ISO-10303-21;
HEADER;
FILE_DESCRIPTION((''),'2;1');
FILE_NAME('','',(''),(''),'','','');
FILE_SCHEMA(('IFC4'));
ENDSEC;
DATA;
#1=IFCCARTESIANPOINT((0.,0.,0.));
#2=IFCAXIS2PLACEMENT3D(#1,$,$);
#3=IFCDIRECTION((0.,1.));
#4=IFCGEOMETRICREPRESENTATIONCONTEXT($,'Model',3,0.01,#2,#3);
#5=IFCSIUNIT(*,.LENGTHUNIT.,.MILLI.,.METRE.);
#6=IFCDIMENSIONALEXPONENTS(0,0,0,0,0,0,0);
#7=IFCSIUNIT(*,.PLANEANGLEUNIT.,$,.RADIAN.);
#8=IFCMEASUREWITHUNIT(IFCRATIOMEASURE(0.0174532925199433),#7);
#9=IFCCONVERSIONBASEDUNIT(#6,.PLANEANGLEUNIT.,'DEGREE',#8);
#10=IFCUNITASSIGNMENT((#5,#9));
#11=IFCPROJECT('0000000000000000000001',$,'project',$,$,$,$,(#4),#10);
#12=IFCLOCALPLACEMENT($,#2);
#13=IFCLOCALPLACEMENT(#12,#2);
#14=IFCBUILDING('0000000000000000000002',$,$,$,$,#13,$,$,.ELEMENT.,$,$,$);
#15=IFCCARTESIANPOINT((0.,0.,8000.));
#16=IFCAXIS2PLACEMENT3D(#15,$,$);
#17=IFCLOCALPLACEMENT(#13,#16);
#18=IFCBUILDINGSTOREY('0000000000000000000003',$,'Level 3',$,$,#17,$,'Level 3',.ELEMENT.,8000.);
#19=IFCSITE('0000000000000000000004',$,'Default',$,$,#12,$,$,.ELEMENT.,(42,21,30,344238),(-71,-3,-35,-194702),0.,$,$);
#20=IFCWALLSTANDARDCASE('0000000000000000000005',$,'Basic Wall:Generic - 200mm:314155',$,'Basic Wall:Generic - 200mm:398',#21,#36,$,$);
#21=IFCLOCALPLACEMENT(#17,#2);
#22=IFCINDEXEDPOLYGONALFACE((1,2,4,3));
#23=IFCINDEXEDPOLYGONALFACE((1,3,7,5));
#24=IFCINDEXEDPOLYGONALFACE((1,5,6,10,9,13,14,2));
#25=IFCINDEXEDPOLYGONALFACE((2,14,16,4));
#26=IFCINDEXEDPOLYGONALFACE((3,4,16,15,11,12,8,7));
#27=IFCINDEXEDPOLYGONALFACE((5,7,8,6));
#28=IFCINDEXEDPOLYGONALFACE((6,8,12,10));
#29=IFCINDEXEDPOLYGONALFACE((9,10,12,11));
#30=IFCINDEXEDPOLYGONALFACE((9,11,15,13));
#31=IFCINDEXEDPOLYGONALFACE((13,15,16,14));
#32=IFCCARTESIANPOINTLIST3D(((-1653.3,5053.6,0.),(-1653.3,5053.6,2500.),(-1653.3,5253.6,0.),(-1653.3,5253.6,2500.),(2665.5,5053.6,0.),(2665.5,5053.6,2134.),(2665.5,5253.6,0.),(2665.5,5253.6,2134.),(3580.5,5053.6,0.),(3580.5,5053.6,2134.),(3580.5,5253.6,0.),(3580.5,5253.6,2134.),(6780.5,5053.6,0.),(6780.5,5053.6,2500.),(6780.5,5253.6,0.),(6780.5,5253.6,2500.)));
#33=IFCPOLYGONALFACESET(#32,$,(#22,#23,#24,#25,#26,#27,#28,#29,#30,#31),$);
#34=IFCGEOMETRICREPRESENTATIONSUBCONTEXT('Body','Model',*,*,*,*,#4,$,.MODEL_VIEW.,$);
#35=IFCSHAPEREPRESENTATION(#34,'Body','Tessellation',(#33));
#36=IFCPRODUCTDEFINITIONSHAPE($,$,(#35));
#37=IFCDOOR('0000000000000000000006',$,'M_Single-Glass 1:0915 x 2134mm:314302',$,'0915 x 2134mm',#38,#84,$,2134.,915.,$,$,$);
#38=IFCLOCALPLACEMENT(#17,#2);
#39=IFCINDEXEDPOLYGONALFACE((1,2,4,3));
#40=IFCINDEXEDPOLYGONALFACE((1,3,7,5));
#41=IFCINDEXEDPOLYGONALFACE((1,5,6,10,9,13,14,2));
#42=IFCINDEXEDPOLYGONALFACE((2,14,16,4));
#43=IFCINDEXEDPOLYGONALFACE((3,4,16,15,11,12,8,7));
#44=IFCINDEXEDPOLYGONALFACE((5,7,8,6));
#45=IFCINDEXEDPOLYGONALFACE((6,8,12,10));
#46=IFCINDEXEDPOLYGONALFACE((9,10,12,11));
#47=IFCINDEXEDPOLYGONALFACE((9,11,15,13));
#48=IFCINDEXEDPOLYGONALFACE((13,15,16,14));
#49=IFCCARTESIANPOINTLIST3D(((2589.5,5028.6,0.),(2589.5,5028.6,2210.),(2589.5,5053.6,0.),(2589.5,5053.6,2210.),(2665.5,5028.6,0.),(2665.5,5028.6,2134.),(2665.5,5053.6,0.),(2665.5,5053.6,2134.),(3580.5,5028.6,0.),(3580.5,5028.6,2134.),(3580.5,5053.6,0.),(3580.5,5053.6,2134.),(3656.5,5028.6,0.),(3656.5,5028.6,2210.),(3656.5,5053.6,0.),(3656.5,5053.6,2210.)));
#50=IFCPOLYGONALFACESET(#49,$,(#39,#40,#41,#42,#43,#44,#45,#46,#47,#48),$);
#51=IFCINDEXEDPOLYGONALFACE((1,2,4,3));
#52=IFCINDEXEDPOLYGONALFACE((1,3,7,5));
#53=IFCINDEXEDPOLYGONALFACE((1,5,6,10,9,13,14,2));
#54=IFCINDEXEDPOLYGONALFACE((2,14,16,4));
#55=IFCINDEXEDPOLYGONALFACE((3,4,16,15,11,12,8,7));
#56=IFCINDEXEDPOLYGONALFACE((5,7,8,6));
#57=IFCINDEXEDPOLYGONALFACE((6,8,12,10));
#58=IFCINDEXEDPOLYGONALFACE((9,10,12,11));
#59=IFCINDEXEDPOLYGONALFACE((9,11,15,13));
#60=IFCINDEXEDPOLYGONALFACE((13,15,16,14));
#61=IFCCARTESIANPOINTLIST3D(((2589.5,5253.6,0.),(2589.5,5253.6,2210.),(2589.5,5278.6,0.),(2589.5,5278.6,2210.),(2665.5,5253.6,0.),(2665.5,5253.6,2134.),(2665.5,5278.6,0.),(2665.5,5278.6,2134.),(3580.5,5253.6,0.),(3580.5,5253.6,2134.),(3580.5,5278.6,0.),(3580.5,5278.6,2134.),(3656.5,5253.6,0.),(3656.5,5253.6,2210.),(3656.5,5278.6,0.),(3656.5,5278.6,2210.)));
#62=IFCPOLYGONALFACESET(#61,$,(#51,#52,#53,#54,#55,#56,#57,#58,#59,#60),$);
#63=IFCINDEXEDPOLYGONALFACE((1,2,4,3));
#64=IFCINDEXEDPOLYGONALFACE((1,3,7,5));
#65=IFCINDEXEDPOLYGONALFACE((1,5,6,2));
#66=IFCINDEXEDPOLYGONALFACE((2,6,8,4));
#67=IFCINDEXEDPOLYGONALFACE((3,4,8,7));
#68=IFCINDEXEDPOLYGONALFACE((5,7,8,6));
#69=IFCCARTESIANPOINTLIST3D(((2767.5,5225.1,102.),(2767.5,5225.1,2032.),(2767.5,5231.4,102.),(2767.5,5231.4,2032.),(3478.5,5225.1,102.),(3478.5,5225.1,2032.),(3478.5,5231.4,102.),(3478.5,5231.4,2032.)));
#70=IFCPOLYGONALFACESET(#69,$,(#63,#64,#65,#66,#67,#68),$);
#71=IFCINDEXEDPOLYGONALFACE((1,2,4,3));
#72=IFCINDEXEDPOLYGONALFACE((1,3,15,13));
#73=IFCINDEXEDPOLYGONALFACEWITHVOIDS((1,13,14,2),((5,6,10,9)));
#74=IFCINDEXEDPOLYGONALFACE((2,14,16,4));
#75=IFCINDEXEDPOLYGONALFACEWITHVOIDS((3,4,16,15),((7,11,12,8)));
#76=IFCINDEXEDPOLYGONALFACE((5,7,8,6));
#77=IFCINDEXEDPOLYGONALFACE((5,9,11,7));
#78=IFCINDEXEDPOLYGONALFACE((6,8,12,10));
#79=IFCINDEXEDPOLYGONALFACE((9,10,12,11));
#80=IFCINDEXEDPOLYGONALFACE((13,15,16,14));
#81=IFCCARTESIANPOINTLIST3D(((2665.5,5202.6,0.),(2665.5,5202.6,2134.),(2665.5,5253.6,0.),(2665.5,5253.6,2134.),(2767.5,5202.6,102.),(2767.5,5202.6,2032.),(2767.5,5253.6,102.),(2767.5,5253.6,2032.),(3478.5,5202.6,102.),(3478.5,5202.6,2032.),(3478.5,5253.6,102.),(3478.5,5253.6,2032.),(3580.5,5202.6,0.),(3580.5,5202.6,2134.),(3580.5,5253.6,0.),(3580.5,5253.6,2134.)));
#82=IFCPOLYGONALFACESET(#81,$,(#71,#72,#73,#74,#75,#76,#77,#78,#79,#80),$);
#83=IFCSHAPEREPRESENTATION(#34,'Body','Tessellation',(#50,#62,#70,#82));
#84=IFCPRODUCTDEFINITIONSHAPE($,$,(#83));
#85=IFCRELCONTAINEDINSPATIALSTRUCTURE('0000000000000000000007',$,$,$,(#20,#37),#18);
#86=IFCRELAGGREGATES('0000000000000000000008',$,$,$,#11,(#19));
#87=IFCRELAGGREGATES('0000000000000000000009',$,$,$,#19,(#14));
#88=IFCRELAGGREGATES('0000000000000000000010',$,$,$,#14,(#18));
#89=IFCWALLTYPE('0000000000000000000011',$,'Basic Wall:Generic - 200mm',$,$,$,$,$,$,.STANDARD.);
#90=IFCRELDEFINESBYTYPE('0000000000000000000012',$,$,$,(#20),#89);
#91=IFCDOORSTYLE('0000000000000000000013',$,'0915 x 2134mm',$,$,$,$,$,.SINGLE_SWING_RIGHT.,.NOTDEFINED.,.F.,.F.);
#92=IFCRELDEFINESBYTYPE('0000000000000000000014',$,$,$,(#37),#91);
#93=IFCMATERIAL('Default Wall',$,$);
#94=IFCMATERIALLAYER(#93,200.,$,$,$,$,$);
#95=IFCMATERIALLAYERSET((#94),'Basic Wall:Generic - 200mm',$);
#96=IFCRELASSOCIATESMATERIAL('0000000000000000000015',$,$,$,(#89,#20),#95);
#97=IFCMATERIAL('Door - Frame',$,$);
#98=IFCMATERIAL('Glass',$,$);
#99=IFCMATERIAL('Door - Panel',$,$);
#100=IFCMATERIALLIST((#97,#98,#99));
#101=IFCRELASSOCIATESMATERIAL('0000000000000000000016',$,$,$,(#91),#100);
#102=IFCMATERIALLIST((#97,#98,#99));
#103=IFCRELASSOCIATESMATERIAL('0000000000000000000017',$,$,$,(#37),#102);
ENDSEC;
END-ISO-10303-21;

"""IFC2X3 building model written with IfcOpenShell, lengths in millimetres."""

from ifc_helpers import new_model, entity, si_unit, converted_unit, direction, frame, frame_2d, origin, place, context, subcontext, project, spatial, polyline, rectangle, outline, extrude, source, transform, mapped, material, material_list, layer, layer_set, layer_usage, type_object, type_shapes, element, fill, save


model = new_model("IFC2X3")

# Units and contexts
model_context = context("Model", 3, precision=0.01, world=origin(), true_north=direction((0.0, 1.0)))
body_context = subcontext(model_context, "Body", "Model", "MODEL_VIEW")
ifc_project = project(units=[si_unit("LENGTHUNIT", "METRE", prefix="MILLI"), converted_unit("PLANEANGLEUNIT", "DEGREE", entity("IfcRatioMeasure", 0.0174532925199433), si_unit("PLANEANGLEUNIT", "RADIAN"), dimensions=[0, 0, 0, 0, 0, 0, 0])], contexts=[model_context])

# Site, building, storey
site_placement = place(None, origin())
site = spatial("IfcSite", under=ifc_project, at=site_placement, Name="Default", CompositionType="ELEMENT", RefLatitude=(42, 21, 30, 344238), RefLongitude=(-71, -3, -35, -194702), RefElevation=0.0)
building_placement = place(site_placement, origin())
building = spatial("IfcBuilding", under=site, at=building_placement, CompositionType="ELEMENT")
storey_placement = place(building_placement, frame((0.0, 0.0, 8000.0)))
storey = spatial("IfcBuildingStorey", under=building, at=storey_placement, Name="Level 3", LongName="Level 3", CompositionType="ELEMENT", Elevation=8000.0)

# Shared definitions
ifc_material_1 = material(Name="Default Wall")
ifc_layer_1 = layer(ifc_material_1, 200.0)
ifc_layer_set_1 = layer_set([ifc_layer_1], Name="Basic Wall:Generic - 200mm")
wall_type = type_object("IfcWallType", Name="Basic Wall:Generic - 200mm", PredefinedType="STANDARD", material=ifc_layer_set_1)
ifc_material_2 = material(Name="Glass")

# Wall, opening, door
ifc_layer_usage_1 = layer_usage(ifc_layer_set_1, "AXIS2", "NEGATIVE", 100.0)
wall_1_placement = place(storey_placement, frame((-1653.3, 5153.6, 0.0)))
wall_1 = element("IfcWallStandardCase", 1, at=wall_1_placement, inside=storey, type_object=wall_type, material=ifc_layer_usage_1, Name="Basic Wall:Generic - 200mm:314155", ObjectType="Basic Wall:Generic - 200mm:398", context=body_context, shape_type="SweptSolid", body=[
    extrude(rectangle(XDim=8433.8, YDim=200.0, at=frame_2d((4216.9, 0.0), x_axis=(-1.0, 0.0))), origin(), (0.0, 0.0, 1.0), 2500.0),
])
opening_1_placement = place(wall_1_placement, frame((4318.8, -100.0, 0.0)))
opening_1 = element("IfcOpeningElement", 2, at=opening_1_placement, cuts=wall_1, ObjectType="Opening", context=body_context, shape_type="SweptSolid", body=[
    extrude(rectangle(XDim=915.0, YDim=2134.0, at=frame_2d((1067.0, 457.5), x_axis=(0.0, 1.0))), frame((0.0, 0.0, 0.0), z_axis=(0.0, 1.0, 0.0), x_axis=(0.0, 0.0, 1.0)), (0.0, 0.0, 1.0), 200.0),
])
ifc_material_3 = material(Name="Door - Frame")
ifc_material_4 = material(Name="Door - Panel")
ifc_material_list_1 = material_list([ifc_material_3, ifc_material_2, ifc_material_4])
ifc_material_list_2 = material_list([ifc_material_3, ifc_material_2, ifc_material_4])
door_style = type_object("IfcDoorStyle", Name="0915 x 2134mm", ConstructionType="NOTDEFINED", OperationType="SINGLE_SWING_RIGHT", ParameterTakesPrecedence=False, Sizeable=False, material=ifc_material_list_2)
shared_shape_1 = source(origin(), body_context, "Body", "SweptSolid", [
    extrude(outline(polyline([(-457.5, -1048.0), (-457.5, 1086.0), (-533.5, 1086.0), (-533.5, -1124.0), (533.5, -1124.0), (533.5, 1086.0), (457.5, 1086.0), (457.5, -1048.0), (-457.5, -1048.0)])), frame((457.5, -25.0, 1086.0), z_axis=(0.0, -1.0, 0.0), x_axis=(-1.0, 0.0, 0.0)), (0.0, 0.0, -1.0), 25.0),
    extrude(outline(polyline([(-457.5, -1048.0), (-457.5, 1086.0), (-533.5, 1086.0), (-533.5, -1124.0), (533.5, -1124.0), (533.5, 1086.0), (457.5, 1086.0), (457.5, -1048.0), (-457.5, -1048.0)])), frame((457.5, 200.0, 1086.0), z_axis=(0.0, -1.0, 0.0), x_axis=(-1.0, 0.0, 0.0)), (0.0, 0.0, -1.0), 25.0),
    extrude(rectangle(XDim=6.3, YDim=711.0, at=frame_2d((0.0, 0.0), x_axis=(1.0, 0.0))), frame((457.5, 174.6, 102.0), z_axis=(0.0, 0.0, 1.0), x_axis=(0.0, 1.0, 0.0)), (0.0, 0.0, 1.0), 1930.0),
    extrude(outline(polyline([(-1067.0, -457.5), (1067.0, -457.5), (1067.0, 457.5), (-1067.0, 457.5), (-1067.0, -457.5)]), holes=[polyline([(-965.0, 355.5), (965.0, 355.5), (965.0, -355.5), (-965.0, -355.5), (-965.0, 355.5)])]), frame((457.5, 149.0, 1067.0), z_axis=(0.0, 1.0, 0.0), x_axis=(0.0, 0.0, -1.0)), (0.0, 0.0, 1.0), 51.0),
])
type_shapes(door_style, [shared_shape_1])
door_placement = place(opening_1_placement, origin())
door = element("IfcDoor", 3, at=door_placement, inside=storey, type_object=door_style, material=ifc_material_list_1, Name="M_Single-Glass 1:0915 x 2134mm:314302", ObjectType="0915 x 2134mm", OverallHeight=2134.0, OverallWidth=915.0, context=body_context, shape_type="MappedRepresentation", body=[
    mapped(shared_shape_1, transform((0.0, 0.0, 0.0), scale=1.0)),
])
fill(opening_1, door)

save(model, "model.ifc")
